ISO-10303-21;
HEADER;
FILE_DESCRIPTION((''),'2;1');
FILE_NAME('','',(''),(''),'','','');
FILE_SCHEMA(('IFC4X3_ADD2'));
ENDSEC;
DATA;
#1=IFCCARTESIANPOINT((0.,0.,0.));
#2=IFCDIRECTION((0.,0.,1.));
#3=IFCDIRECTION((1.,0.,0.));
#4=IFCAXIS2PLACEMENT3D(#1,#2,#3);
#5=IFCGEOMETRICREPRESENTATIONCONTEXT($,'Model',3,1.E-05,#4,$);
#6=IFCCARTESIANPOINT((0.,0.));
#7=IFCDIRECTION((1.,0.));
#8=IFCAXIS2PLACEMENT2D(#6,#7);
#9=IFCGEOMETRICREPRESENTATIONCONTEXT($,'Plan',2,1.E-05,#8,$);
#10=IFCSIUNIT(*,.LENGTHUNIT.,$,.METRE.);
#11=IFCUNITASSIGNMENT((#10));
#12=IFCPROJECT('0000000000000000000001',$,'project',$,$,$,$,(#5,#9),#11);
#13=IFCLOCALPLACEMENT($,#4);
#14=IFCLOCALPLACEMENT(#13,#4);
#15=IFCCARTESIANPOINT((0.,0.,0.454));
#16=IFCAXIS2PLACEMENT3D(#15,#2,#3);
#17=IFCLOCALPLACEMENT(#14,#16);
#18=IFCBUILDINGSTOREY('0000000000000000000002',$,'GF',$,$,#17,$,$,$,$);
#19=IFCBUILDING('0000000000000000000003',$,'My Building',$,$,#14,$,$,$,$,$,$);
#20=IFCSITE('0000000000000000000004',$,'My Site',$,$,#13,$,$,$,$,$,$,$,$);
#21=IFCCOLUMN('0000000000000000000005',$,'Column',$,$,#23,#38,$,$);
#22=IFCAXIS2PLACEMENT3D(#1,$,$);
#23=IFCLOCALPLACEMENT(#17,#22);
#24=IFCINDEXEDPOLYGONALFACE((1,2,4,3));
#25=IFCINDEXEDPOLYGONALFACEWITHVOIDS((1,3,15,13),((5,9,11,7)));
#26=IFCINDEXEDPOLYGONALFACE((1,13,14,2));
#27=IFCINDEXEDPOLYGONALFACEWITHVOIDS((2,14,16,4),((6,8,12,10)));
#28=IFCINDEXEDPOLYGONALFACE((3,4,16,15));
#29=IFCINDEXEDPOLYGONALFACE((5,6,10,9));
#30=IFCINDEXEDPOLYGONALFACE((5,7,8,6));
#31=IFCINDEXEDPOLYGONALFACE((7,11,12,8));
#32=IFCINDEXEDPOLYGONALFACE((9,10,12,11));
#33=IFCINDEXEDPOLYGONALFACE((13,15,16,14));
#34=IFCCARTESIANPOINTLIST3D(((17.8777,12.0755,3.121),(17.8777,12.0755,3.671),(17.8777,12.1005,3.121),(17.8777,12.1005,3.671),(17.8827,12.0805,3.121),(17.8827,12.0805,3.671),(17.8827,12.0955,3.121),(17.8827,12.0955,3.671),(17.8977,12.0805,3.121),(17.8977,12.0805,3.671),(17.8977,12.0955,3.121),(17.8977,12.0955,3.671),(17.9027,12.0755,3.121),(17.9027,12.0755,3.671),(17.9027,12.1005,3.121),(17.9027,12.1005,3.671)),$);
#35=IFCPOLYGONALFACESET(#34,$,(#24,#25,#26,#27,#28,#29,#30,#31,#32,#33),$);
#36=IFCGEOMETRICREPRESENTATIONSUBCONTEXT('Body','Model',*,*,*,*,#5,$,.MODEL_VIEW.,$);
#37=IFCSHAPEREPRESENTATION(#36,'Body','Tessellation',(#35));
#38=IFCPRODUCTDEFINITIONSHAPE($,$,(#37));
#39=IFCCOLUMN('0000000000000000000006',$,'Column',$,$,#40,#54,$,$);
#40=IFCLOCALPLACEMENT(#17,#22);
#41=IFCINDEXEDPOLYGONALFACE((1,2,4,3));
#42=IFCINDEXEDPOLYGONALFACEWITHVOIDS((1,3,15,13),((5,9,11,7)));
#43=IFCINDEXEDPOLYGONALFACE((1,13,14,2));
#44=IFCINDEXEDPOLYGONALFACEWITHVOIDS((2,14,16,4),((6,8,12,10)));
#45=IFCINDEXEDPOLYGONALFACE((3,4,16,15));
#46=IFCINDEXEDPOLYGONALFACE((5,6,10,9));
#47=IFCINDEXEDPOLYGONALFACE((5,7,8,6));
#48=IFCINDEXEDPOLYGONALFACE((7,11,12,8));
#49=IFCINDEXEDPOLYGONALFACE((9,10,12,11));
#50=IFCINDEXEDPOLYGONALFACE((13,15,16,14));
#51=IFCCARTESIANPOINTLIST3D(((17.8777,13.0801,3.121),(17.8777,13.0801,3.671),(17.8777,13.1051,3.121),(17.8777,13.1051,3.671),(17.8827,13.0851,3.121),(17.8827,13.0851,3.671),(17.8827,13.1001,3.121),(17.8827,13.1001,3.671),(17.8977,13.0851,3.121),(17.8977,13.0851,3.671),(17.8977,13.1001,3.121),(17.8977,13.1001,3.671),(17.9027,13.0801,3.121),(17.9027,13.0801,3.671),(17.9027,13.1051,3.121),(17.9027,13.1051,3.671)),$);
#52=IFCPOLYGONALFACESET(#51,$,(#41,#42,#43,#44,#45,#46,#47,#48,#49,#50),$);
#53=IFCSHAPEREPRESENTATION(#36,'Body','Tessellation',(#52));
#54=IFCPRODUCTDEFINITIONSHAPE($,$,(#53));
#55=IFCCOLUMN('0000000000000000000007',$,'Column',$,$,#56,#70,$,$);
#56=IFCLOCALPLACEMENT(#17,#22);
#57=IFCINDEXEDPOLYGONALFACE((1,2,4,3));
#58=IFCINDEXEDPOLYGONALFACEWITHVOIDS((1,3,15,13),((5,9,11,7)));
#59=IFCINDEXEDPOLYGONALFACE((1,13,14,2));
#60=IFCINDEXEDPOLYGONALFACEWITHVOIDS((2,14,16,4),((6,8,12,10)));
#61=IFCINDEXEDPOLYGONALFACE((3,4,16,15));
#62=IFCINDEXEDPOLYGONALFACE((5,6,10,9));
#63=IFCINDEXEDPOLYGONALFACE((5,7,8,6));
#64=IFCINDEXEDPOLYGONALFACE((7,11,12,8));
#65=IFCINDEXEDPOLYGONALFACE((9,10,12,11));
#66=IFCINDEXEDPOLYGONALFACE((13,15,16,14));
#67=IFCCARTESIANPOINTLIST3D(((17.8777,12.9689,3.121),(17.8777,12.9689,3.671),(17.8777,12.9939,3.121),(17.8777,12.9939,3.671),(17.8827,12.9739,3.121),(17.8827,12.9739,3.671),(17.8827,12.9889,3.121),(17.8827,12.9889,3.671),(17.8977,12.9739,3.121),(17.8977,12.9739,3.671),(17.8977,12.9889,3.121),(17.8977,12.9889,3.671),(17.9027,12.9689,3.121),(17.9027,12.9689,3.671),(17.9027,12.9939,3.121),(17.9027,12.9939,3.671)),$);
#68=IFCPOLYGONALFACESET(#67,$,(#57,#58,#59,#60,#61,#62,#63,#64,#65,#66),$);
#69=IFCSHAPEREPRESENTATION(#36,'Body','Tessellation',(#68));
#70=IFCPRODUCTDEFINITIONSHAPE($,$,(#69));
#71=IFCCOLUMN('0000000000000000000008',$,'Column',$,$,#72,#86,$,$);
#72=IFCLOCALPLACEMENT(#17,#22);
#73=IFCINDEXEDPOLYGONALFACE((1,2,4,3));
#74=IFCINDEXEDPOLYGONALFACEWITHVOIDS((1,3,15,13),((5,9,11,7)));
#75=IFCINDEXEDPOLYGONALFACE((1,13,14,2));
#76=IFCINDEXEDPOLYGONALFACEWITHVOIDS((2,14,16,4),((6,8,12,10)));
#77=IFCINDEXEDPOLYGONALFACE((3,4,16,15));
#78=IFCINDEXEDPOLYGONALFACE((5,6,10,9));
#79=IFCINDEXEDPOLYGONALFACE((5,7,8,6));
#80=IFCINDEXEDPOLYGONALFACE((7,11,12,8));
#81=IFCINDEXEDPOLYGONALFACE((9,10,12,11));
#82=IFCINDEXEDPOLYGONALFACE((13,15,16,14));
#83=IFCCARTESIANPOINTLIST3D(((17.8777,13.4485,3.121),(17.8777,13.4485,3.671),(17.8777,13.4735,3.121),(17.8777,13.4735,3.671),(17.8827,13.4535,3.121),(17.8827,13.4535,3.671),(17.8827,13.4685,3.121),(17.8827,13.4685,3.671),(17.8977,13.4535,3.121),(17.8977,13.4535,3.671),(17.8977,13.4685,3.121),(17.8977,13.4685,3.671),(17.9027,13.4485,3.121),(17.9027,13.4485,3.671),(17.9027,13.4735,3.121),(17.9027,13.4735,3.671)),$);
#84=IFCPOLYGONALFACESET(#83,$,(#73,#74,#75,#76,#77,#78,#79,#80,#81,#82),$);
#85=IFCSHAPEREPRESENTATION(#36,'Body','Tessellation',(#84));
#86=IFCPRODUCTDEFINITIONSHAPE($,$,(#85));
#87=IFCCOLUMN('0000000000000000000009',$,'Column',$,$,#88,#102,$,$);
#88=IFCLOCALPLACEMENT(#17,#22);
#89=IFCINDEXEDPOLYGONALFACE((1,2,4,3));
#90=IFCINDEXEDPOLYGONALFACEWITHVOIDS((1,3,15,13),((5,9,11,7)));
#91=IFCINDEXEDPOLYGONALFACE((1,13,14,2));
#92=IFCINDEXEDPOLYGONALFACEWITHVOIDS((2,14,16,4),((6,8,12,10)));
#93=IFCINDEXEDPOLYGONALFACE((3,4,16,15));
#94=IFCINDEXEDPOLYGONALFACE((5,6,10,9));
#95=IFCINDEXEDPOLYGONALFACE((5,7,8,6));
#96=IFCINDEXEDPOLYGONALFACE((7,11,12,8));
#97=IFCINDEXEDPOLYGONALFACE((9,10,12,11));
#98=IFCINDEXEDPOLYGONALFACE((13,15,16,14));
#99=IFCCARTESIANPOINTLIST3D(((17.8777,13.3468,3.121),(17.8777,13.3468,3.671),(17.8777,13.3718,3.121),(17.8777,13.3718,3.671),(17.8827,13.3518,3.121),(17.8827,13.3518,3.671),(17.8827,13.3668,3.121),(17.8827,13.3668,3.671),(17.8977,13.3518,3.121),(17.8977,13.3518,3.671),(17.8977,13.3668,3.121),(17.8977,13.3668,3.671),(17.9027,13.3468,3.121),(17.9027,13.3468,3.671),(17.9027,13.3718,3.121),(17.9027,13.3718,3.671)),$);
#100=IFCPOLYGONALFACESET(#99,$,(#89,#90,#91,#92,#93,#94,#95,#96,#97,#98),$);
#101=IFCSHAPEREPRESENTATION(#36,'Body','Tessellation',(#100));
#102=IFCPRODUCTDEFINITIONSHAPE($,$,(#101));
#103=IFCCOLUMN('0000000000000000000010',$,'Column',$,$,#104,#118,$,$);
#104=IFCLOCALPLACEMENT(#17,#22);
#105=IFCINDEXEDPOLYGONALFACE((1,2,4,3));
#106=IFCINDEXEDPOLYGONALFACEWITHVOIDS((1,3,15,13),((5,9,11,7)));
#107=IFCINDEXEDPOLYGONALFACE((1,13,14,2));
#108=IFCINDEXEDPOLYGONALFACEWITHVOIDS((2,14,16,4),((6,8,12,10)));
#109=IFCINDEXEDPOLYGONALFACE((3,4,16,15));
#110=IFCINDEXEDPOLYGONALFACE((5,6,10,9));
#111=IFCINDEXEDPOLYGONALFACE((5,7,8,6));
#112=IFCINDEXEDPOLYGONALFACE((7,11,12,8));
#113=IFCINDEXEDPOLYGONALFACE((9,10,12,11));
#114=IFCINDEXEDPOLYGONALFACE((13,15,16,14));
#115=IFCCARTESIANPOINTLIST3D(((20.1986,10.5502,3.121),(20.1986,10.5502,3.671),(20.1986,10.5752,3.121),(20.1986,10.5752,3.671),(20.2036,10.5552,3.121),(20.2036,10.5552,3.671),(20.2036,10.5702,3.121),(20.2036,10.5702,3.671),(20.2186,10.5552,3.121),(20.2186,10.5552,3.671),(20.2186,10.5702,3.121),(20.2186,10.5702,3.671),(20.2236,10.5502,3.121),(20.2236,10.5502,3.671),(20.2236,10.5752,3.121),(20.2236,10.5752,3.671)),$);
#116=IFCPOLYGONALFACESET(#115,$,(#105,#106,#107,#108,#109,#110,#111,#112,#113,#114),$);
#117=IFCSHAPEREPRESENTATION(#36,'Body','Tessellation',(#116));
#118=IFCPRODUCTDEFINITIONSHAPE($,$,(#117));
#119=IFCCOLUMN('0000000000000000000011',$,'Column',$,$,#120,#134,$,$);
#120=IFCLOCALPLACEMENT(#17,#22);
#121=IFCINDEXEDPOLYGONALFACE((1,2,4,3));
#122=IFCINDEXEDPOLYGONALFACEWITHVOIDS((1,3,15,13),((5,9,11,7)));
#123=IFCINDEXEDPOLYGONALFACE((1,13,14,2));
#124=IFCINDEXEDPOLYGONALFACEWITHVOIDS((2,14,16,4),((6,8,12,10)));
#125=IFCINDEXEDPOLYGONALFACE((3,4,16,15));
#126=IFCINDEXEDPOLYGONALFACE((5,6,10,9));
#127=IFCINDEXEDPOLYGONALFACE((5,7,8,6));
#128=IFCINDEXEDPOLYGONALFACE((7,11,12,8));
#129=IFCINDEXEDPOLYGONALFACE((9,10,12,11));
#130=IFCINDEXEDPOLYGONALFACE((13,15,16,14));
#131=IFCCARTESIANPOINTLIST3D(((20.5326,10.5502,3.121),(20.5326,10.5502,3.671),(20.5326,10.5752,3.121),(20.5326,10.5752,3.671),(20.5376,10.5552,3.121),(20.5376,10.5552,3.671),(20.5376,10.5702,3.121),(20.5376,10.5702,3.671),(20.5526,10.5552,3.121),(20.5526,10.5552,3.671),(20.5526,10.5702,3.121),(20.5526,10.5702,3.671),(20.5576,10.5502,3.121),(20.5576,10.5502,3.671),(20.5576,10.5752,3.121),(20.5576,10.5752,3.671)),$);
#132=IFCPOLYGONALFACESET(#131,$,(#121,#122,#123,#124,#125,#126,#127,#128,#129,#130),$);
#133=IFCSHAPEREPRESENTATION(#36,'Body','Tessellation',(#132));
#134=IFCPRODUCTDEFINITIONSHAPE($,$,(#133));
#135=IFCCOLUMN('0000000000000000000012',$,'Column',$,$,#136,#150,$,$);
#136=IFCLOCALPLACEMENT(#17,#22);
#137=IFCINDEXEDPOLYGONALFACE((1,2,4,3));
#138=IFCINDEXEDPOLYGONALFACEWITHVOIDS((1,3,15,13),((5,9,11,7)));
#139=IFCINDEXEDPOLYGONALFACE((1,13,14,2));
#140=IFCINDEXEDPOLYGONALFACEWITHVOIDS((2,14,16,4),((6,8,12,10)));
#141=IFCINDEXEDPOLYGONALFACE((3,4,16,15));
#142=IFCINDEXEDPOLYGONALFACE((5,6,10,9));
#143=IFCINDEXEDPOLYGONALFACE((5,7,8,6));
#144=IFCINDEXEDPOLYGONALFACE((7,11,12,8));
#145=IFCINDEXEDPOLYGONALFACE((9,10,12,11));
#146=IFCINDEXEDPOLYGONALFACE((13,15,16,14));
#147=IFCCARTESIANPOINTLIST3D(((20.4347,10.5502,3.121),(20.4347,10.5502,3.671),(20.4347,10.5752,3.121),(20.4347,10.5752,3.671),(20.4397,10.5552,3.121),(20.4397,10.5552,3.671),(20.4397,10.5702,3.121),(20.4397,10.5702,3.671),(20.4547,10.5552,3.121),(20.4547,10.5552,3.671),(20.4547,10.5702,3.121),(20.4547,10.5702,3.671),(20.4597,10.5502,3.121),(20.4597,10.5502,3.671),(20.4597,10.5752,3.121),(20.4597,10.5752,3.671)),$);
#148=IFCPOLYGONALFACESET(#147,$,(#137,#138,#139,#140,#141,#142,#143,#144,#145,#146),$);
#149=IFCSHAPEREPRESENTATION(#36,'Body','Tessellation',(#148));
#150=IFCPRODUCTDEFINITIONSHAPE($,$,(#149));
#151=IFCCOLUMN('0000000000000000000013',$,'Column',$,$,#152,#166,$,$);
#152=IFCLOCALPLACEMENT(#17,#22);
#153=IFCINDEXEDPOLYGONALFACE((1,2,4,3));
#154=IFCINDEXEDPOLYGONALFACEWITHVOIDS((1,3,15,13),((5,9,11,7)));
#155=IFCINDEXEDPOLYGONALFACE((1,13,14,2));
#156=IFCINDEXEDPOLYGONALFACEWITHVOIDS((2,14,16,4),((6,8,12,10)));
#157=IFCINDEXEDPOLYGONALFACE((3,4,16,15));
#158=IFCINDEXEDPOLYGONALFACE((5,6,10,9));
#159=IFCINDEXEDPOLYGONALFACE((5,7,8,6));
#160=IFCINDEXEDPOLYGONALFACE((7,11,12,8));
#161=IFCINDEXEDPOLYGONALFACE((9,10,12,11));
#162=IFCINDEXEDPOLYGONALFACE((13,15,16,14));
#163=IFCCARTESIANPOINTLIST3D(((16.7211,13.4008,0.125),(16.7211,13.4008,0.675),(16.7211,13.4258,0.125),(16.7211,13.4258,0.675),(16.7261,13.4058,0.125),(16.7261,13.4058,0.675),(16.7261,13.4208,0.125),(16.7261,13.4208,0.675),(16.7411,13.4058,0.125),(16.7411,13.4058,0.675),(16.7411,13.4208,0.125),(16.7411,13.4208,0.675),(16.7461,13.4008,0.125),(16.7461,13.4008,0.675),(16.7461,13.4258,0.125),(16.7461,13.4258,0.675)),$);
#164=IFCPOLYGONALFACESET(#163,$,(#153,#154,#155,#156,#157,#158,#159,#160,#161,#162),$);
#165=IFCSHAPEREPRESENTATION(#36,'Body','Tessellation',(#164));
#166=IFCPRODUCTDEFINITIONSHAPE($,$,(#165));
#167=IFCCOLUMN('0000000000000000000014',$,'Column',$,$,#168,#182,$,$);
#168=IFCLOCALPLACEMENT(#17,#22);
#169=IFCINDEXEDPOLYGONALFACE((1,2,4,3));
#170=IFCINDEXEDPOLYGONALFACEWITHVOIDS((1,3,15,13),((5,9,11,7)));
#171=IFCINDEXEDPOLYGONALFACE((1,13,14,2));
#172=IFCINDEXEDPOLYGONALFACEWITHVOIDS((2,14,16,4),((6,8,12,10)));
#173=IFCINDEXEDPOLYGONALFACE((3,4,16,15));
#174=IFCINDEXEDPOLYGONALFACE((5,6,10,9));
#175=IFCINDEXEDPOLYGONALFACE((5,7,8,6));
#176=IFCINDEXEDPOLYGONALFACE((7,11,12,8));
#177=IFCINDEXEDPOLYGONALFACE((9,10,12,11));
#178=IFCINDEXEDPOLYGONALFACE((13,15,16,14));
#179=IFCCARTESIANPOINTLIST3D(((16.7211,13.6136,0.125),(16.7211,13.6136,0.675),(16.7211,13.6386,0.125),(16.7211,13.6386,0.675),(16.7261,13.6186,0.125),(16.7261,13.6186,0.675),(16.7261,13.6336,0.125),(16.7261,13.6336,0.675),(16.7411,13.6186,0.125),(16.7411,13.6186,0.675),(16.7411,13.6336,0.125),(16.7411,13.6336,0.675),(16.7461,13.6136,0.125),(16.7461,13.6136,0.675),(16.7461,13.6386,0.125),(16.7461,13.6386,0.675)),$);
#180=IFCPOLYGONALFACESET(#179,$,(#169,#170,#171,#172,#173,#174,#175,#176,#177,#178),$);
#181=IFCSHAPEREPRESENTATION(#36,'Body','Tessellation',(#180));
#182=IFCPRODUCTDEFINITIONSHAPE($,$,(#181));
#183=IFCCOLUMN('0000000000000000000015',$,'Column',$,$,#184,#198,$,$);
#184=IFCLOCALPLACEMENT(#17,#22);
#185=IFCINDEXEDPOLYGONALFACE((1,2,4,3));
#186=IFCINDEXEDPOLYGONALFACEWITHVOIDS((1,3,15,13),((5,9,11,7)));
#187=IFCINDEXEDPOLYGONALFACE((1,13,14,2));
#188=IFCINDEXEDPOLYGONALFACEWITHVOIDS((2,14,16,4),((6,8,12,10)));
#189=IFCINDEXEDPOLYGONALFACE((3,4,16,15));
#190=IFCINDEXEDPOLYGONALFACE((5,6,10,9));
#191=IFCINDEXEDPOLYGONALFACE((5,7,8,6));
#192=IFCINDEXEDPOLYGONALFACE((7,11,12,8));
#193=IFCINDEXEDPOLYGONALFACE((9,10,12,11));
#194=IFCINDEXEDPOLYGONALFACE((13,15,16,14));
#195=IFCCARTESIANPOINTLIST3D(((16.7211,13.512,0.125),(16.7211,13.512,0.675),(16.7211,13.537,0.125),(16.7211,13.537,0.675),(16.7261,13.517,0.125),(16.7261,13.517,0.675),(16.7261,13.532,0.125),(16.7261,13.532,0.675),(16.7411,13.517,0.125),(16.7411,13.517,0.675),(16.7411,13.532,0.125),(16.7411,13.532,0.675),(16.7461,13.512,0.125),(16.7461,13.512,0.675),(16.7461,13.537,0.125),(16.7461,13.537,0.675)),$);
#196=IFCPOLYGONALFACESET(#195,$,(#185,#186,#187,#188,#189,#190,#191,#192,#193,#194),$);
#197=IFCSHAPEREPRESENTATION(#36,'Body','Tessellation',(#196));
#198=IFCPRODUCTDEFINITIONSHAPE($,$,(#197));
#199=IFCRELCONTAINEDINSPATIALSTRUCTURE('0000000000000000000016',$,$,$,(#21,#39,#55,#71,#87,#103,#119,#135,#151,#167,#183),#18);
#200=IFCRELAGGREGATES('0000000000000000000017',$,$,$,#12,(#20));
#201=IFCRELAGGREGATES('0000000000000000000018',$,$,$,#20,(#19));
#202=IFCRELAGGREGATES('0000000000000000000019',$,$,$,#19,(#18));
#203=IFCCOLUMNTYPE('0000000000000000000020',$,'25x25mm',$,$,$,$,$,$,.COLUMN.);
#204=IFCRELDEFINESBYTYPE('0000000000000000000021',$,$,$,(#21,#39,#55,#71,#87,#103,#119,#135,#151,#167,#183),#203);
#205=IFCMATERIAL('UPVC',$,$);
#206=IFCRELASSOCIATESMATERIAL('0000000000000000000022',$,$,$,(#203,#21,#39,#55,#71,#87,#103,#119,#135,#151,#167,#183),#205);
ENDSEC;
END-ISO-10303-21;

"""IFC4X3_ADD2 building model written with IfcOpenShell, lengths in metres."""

from ifc_helpers import new_model, si_unit, frame, origin_with_axes, origin_2d_with_axis, place, context, subcontext, project, spatial, hollow_rectangle, extrude, material, material_profile, profile_set, profile_usage, type_object, element, save


model = new_model("IFC4X3_ADD2")

# Units and contexts
model_context = context("Model", 3, precision=1e-05, world=origin_with_axes())
plan_context = context("Plan", 2, precision=1e-05, world=origin_2d_with_axis())
body_context = subcontext(model_context, "Body", "Model", "MODEL_VIEW")
ifc_project = project(units=[si_unit("LENGTHUNIT", "METRE")], contexts=[model_context, plan_context])

# Site, building, storey
site_placement = place(None, origin_with_axes())
site = spatial("IfcSite", under=ifc_project, at=site_placement, Name="My Site")
building_placement = place(site_placement, origin_with_axes())
building = spatial("IfcBuilding", under=site, at=building_placement, Name="My Building")
storey_placement = place(building_placement, frame((0.0, 0.0, 0.454), z_axis=(0.0, 0.0, 1.0), x_axis=(1.0, 0.0, 0.0)))
storey = spatial("IfcBuildingStorey", under=building, at=storey_placement, Name="GF")

# Columns
ifc_material_1 = material(Name="UPVC")
ifc_material_profile_1 = material_profile(ifc_material_1, hollow_rectangle(XDim=0.025, YDim=0.025, WallThickness=0.005))
ifc_profile_set_1 = profile_set([ifc_material_profile_1])
column_type_1 = type_object("IfcColumnType", Name="25x25mm", PredefinedType="COLUMN", material=ifc_profile_set_1)
ifc_profile_usage_1 = profile_usage(ifc_profile_set_1)
column_1_placement = place(storey_placement, frame((17.8902, 12.088, 3.121), z_axis=(0.0, 0.0, 1.0), x_axis=(0.0, -1.0, 0.0)))
element("IfcColumn", 1, at=column_1_placement, inside=storey, type_object=column_type_1, material=ifc_profile_usage_1, Name="Column", context=body_context, shape_type="SweptSolid", body=[
    extrude(hollow_rectangle(XDim=0.025, YDim=0.025, WallThickness=0.005), origin_with_axes(), (0.0, 0.0, 1.0), 0.55),
])
ifc_profile_usage_2 = profile_usage(ifc_profile_set_1)
column_2_placement = place(storey_placement, frame((17.8902, 13.0926, 3.121), z_axis=(0.0, 0.0, 1.0), x_axis=(0.0, -1.0, 0.0)))
element("IfcColumn", 2, at=column_2_placement, inside=storey, type_object=column_type_1, material=ifc_profile_usage_2, Name="Column", context=body_context, shape_type="SweptSolid", body=[
    extrude(hollow_rectangle(XDim=0.025, YDim=0.025, WallThickness=0.005), origin_with_axes(), (0.0, 0.0, 1.0), 0.55),
])
ifc_profile_usage_3 = profile_usage(ifc_profile_set_1)
column_3_placement = place(storey_placement, frame((17.8902, 12.9814, 3.121), z_axis=(0.0, 0.0, 1.0), x_axis=(0.0, -1.0, 0.0)))
element("IfcColumn", 3, at=column_3_placement, inside=storey, type_object=column_type_1, material=ifc_profile_usage_3, Name="Column", context=body_context, shape_type="SweptSolid", body=[
    extrude(hollow_rectangle(XDim=0.025, YDim=0.025, WallThickness=0.005), origin_with_axes(), (0.0, 0.0, 1.0), 0.55),
])
ifc_profile_usage_4 = profile_usage(ifc_profile_set_1)
column_4_placement = place(storey_placement, frame((17.8902, 13.461, 3.121), z_axis=(0.0, 0.0, 1.0), x_axis=(0.0, -1.0, 0.0)))
element("IfcColumn", 4, at=column_4_placement, inside=storey, type_object=column_type_1, material=ifc_profile_usage_4, Name="Column", context=body_context, shape_type="SweptSolid", body=[
    extrude(hollow_rectangle(XDim=0.025, YDim=0.025, WallThickness=0.005), origin_with_axes(), (0.0, 0.0, 1.0), 0.55),
])
ifc_profile_usage_5 = profile_usage(ifc_profile_set_1)
column_5_placement = place(storey_placement, frame((17.8902, 13.3593, 3.121), z_axis=(0.0, 0.0, 1.0), x_axis=(0.0, -1.0, 0.0)))
element("IfcColumn", 5, at=column_5_placement, inside=storey, type_object=column_type_1, material=ifc_profile_usage_5, Name="Column", context=body_context, shape_type="SweptSolid", body=[
    extrude(hollow_rectangle(XDim=0.025, YDim=0.025, WallThickness=0.005), origin_with_axes(), (0.0, 0.0, 1.0), 0.55),
])
ifc_profile_usage_6 = profile_usage(ifc_profile_set_1)
column_6_placement = place(storey_placement, frame((20.2111, 10.5627, 3.121), z_axis=(0.0, 0.0, 1.0), x_axis=(0.0, -1.0, 0.0)))
element("IfcColumn", 6, at=column_6_placement, inside=storey, type_object=column_type_1, material=ifc_profile_usage_6, Name="Column", context=body_context, shape_type="SweptSolid", body=[
    extrude(hollow_rectangle(XDim=0.025, YDim=0.025, WallThickness=0.005), origin_with_axes(), (0.0, 0.0, 1.0), 0.55),
])
ifc_profile_usage_7 = profile_usage(ifc_profile_set_1)
column_7_placement = place(storey_placement, frame((20.5451, 10.5627, 3.121), z_axis=(0.0, 0.0, 1.0), x_axis=(0.0, -1.0, 0.0)))
element("IfcColumn", 7, at=column_7_placement, inside=storey, type_object=column_type_1, material=ifc_profile_usage_7, Name="Column", context=body_context, shape_type="SweptSolid", body=[
    extrude(hollow_rectangle(XDim=0.025, YDim=0.025, WallThickness=0.005), origin_with_axes(), (0.0, 0.0, 1.0), 0.55),
])
ifc_profile_usage_8 = profile_usage(ifc_profile_set_1)
column_8_placement = place(storey_placement, frame((20.4472, 10.5627, 3.121), z_axis=(0.0, 0.0, 1.0), x_axis=(0.0, -1.0, 0.0)))
element("IfcColumn", 8, at=column_8_placement, inside=storey, type_object=column_type_1, material=ifc_profile_usage_8, Name="Column", context=body_context, shape_type="SweptSolid", body=[
    extrude(hollow_rectangle(XDim=0.025, YDim=0.025, WallThickness=0.005), origin_with_axes(), (0.0, 0.0, 1.0), 0.55),
])
ifc_profile_usage_9 = profile_usage(ifc_profile_set_1)
column_9_placement = place(storey_placement, frame((16.7336, 13.4133, 0.125), z_axis=(0.0, 0.0, 1.0), x_axis=(0.0, -1.0, 0.0)))
element("IfcColumn", 9, at=column_9_placement, inside=storey, type_object=column_type_1, material=ifc_profile_usage_9, Name="Column", context=body_context, shape_type="SweptSolid", body=[
    extrude(hollow_rectangle(XDim=0.025, YDim=0.025, WallThickness=0.005), origin_with_axes(), (0.0, 0.0, 1.0), 0.55),
])
ifc_profile_usage_10 = profile_usage(ifc_profile_set_1)
column_10_placement = place(storey_placement, frame((16.7336, 13.6261, 0.125), z_axis=(0.0, 0.0, 1.0), x_axis=(0.0, -1.0, 0.0)))
element("IfcColumn", 10, at=column_10_placement, inside=storey, type_object=column_type_1, material=ifc_profile_usage_10, Name="Column", context=body_context, shape_type="SweptSolid", body=[
    extrude(hollow_rectangle(XDim=0.025, YDim=0.025, WallThickness=0.005), origin_with_axes(), (0.0, 0.0, 1.0), 0.55),
])
ifc_profile_usage_11 = profile_usage(ifc_profile_set_1)
column_11_placement = place(storey_placement, frame((16.7336, 13.5245, 0.125), z_axis=(0.0, 0.0, 1.0), x_axis=(0.0, -1.0, 0.0)))
element("IfcColumn", 11, at=column_11_placement, inside=storey, type_object=column_type_1, material=ifc_profile_usage_11, Name="Column", context=body_context, shape_type="SweptSolid", body=[
    extrude(hollow_rectangle(XDim=0.025, YDim=0.025, WallThickness=0.005), origin_with_axes(), (0.0, 0.0, 1.0), 0.55),
])

save(model, "model.ifc")
